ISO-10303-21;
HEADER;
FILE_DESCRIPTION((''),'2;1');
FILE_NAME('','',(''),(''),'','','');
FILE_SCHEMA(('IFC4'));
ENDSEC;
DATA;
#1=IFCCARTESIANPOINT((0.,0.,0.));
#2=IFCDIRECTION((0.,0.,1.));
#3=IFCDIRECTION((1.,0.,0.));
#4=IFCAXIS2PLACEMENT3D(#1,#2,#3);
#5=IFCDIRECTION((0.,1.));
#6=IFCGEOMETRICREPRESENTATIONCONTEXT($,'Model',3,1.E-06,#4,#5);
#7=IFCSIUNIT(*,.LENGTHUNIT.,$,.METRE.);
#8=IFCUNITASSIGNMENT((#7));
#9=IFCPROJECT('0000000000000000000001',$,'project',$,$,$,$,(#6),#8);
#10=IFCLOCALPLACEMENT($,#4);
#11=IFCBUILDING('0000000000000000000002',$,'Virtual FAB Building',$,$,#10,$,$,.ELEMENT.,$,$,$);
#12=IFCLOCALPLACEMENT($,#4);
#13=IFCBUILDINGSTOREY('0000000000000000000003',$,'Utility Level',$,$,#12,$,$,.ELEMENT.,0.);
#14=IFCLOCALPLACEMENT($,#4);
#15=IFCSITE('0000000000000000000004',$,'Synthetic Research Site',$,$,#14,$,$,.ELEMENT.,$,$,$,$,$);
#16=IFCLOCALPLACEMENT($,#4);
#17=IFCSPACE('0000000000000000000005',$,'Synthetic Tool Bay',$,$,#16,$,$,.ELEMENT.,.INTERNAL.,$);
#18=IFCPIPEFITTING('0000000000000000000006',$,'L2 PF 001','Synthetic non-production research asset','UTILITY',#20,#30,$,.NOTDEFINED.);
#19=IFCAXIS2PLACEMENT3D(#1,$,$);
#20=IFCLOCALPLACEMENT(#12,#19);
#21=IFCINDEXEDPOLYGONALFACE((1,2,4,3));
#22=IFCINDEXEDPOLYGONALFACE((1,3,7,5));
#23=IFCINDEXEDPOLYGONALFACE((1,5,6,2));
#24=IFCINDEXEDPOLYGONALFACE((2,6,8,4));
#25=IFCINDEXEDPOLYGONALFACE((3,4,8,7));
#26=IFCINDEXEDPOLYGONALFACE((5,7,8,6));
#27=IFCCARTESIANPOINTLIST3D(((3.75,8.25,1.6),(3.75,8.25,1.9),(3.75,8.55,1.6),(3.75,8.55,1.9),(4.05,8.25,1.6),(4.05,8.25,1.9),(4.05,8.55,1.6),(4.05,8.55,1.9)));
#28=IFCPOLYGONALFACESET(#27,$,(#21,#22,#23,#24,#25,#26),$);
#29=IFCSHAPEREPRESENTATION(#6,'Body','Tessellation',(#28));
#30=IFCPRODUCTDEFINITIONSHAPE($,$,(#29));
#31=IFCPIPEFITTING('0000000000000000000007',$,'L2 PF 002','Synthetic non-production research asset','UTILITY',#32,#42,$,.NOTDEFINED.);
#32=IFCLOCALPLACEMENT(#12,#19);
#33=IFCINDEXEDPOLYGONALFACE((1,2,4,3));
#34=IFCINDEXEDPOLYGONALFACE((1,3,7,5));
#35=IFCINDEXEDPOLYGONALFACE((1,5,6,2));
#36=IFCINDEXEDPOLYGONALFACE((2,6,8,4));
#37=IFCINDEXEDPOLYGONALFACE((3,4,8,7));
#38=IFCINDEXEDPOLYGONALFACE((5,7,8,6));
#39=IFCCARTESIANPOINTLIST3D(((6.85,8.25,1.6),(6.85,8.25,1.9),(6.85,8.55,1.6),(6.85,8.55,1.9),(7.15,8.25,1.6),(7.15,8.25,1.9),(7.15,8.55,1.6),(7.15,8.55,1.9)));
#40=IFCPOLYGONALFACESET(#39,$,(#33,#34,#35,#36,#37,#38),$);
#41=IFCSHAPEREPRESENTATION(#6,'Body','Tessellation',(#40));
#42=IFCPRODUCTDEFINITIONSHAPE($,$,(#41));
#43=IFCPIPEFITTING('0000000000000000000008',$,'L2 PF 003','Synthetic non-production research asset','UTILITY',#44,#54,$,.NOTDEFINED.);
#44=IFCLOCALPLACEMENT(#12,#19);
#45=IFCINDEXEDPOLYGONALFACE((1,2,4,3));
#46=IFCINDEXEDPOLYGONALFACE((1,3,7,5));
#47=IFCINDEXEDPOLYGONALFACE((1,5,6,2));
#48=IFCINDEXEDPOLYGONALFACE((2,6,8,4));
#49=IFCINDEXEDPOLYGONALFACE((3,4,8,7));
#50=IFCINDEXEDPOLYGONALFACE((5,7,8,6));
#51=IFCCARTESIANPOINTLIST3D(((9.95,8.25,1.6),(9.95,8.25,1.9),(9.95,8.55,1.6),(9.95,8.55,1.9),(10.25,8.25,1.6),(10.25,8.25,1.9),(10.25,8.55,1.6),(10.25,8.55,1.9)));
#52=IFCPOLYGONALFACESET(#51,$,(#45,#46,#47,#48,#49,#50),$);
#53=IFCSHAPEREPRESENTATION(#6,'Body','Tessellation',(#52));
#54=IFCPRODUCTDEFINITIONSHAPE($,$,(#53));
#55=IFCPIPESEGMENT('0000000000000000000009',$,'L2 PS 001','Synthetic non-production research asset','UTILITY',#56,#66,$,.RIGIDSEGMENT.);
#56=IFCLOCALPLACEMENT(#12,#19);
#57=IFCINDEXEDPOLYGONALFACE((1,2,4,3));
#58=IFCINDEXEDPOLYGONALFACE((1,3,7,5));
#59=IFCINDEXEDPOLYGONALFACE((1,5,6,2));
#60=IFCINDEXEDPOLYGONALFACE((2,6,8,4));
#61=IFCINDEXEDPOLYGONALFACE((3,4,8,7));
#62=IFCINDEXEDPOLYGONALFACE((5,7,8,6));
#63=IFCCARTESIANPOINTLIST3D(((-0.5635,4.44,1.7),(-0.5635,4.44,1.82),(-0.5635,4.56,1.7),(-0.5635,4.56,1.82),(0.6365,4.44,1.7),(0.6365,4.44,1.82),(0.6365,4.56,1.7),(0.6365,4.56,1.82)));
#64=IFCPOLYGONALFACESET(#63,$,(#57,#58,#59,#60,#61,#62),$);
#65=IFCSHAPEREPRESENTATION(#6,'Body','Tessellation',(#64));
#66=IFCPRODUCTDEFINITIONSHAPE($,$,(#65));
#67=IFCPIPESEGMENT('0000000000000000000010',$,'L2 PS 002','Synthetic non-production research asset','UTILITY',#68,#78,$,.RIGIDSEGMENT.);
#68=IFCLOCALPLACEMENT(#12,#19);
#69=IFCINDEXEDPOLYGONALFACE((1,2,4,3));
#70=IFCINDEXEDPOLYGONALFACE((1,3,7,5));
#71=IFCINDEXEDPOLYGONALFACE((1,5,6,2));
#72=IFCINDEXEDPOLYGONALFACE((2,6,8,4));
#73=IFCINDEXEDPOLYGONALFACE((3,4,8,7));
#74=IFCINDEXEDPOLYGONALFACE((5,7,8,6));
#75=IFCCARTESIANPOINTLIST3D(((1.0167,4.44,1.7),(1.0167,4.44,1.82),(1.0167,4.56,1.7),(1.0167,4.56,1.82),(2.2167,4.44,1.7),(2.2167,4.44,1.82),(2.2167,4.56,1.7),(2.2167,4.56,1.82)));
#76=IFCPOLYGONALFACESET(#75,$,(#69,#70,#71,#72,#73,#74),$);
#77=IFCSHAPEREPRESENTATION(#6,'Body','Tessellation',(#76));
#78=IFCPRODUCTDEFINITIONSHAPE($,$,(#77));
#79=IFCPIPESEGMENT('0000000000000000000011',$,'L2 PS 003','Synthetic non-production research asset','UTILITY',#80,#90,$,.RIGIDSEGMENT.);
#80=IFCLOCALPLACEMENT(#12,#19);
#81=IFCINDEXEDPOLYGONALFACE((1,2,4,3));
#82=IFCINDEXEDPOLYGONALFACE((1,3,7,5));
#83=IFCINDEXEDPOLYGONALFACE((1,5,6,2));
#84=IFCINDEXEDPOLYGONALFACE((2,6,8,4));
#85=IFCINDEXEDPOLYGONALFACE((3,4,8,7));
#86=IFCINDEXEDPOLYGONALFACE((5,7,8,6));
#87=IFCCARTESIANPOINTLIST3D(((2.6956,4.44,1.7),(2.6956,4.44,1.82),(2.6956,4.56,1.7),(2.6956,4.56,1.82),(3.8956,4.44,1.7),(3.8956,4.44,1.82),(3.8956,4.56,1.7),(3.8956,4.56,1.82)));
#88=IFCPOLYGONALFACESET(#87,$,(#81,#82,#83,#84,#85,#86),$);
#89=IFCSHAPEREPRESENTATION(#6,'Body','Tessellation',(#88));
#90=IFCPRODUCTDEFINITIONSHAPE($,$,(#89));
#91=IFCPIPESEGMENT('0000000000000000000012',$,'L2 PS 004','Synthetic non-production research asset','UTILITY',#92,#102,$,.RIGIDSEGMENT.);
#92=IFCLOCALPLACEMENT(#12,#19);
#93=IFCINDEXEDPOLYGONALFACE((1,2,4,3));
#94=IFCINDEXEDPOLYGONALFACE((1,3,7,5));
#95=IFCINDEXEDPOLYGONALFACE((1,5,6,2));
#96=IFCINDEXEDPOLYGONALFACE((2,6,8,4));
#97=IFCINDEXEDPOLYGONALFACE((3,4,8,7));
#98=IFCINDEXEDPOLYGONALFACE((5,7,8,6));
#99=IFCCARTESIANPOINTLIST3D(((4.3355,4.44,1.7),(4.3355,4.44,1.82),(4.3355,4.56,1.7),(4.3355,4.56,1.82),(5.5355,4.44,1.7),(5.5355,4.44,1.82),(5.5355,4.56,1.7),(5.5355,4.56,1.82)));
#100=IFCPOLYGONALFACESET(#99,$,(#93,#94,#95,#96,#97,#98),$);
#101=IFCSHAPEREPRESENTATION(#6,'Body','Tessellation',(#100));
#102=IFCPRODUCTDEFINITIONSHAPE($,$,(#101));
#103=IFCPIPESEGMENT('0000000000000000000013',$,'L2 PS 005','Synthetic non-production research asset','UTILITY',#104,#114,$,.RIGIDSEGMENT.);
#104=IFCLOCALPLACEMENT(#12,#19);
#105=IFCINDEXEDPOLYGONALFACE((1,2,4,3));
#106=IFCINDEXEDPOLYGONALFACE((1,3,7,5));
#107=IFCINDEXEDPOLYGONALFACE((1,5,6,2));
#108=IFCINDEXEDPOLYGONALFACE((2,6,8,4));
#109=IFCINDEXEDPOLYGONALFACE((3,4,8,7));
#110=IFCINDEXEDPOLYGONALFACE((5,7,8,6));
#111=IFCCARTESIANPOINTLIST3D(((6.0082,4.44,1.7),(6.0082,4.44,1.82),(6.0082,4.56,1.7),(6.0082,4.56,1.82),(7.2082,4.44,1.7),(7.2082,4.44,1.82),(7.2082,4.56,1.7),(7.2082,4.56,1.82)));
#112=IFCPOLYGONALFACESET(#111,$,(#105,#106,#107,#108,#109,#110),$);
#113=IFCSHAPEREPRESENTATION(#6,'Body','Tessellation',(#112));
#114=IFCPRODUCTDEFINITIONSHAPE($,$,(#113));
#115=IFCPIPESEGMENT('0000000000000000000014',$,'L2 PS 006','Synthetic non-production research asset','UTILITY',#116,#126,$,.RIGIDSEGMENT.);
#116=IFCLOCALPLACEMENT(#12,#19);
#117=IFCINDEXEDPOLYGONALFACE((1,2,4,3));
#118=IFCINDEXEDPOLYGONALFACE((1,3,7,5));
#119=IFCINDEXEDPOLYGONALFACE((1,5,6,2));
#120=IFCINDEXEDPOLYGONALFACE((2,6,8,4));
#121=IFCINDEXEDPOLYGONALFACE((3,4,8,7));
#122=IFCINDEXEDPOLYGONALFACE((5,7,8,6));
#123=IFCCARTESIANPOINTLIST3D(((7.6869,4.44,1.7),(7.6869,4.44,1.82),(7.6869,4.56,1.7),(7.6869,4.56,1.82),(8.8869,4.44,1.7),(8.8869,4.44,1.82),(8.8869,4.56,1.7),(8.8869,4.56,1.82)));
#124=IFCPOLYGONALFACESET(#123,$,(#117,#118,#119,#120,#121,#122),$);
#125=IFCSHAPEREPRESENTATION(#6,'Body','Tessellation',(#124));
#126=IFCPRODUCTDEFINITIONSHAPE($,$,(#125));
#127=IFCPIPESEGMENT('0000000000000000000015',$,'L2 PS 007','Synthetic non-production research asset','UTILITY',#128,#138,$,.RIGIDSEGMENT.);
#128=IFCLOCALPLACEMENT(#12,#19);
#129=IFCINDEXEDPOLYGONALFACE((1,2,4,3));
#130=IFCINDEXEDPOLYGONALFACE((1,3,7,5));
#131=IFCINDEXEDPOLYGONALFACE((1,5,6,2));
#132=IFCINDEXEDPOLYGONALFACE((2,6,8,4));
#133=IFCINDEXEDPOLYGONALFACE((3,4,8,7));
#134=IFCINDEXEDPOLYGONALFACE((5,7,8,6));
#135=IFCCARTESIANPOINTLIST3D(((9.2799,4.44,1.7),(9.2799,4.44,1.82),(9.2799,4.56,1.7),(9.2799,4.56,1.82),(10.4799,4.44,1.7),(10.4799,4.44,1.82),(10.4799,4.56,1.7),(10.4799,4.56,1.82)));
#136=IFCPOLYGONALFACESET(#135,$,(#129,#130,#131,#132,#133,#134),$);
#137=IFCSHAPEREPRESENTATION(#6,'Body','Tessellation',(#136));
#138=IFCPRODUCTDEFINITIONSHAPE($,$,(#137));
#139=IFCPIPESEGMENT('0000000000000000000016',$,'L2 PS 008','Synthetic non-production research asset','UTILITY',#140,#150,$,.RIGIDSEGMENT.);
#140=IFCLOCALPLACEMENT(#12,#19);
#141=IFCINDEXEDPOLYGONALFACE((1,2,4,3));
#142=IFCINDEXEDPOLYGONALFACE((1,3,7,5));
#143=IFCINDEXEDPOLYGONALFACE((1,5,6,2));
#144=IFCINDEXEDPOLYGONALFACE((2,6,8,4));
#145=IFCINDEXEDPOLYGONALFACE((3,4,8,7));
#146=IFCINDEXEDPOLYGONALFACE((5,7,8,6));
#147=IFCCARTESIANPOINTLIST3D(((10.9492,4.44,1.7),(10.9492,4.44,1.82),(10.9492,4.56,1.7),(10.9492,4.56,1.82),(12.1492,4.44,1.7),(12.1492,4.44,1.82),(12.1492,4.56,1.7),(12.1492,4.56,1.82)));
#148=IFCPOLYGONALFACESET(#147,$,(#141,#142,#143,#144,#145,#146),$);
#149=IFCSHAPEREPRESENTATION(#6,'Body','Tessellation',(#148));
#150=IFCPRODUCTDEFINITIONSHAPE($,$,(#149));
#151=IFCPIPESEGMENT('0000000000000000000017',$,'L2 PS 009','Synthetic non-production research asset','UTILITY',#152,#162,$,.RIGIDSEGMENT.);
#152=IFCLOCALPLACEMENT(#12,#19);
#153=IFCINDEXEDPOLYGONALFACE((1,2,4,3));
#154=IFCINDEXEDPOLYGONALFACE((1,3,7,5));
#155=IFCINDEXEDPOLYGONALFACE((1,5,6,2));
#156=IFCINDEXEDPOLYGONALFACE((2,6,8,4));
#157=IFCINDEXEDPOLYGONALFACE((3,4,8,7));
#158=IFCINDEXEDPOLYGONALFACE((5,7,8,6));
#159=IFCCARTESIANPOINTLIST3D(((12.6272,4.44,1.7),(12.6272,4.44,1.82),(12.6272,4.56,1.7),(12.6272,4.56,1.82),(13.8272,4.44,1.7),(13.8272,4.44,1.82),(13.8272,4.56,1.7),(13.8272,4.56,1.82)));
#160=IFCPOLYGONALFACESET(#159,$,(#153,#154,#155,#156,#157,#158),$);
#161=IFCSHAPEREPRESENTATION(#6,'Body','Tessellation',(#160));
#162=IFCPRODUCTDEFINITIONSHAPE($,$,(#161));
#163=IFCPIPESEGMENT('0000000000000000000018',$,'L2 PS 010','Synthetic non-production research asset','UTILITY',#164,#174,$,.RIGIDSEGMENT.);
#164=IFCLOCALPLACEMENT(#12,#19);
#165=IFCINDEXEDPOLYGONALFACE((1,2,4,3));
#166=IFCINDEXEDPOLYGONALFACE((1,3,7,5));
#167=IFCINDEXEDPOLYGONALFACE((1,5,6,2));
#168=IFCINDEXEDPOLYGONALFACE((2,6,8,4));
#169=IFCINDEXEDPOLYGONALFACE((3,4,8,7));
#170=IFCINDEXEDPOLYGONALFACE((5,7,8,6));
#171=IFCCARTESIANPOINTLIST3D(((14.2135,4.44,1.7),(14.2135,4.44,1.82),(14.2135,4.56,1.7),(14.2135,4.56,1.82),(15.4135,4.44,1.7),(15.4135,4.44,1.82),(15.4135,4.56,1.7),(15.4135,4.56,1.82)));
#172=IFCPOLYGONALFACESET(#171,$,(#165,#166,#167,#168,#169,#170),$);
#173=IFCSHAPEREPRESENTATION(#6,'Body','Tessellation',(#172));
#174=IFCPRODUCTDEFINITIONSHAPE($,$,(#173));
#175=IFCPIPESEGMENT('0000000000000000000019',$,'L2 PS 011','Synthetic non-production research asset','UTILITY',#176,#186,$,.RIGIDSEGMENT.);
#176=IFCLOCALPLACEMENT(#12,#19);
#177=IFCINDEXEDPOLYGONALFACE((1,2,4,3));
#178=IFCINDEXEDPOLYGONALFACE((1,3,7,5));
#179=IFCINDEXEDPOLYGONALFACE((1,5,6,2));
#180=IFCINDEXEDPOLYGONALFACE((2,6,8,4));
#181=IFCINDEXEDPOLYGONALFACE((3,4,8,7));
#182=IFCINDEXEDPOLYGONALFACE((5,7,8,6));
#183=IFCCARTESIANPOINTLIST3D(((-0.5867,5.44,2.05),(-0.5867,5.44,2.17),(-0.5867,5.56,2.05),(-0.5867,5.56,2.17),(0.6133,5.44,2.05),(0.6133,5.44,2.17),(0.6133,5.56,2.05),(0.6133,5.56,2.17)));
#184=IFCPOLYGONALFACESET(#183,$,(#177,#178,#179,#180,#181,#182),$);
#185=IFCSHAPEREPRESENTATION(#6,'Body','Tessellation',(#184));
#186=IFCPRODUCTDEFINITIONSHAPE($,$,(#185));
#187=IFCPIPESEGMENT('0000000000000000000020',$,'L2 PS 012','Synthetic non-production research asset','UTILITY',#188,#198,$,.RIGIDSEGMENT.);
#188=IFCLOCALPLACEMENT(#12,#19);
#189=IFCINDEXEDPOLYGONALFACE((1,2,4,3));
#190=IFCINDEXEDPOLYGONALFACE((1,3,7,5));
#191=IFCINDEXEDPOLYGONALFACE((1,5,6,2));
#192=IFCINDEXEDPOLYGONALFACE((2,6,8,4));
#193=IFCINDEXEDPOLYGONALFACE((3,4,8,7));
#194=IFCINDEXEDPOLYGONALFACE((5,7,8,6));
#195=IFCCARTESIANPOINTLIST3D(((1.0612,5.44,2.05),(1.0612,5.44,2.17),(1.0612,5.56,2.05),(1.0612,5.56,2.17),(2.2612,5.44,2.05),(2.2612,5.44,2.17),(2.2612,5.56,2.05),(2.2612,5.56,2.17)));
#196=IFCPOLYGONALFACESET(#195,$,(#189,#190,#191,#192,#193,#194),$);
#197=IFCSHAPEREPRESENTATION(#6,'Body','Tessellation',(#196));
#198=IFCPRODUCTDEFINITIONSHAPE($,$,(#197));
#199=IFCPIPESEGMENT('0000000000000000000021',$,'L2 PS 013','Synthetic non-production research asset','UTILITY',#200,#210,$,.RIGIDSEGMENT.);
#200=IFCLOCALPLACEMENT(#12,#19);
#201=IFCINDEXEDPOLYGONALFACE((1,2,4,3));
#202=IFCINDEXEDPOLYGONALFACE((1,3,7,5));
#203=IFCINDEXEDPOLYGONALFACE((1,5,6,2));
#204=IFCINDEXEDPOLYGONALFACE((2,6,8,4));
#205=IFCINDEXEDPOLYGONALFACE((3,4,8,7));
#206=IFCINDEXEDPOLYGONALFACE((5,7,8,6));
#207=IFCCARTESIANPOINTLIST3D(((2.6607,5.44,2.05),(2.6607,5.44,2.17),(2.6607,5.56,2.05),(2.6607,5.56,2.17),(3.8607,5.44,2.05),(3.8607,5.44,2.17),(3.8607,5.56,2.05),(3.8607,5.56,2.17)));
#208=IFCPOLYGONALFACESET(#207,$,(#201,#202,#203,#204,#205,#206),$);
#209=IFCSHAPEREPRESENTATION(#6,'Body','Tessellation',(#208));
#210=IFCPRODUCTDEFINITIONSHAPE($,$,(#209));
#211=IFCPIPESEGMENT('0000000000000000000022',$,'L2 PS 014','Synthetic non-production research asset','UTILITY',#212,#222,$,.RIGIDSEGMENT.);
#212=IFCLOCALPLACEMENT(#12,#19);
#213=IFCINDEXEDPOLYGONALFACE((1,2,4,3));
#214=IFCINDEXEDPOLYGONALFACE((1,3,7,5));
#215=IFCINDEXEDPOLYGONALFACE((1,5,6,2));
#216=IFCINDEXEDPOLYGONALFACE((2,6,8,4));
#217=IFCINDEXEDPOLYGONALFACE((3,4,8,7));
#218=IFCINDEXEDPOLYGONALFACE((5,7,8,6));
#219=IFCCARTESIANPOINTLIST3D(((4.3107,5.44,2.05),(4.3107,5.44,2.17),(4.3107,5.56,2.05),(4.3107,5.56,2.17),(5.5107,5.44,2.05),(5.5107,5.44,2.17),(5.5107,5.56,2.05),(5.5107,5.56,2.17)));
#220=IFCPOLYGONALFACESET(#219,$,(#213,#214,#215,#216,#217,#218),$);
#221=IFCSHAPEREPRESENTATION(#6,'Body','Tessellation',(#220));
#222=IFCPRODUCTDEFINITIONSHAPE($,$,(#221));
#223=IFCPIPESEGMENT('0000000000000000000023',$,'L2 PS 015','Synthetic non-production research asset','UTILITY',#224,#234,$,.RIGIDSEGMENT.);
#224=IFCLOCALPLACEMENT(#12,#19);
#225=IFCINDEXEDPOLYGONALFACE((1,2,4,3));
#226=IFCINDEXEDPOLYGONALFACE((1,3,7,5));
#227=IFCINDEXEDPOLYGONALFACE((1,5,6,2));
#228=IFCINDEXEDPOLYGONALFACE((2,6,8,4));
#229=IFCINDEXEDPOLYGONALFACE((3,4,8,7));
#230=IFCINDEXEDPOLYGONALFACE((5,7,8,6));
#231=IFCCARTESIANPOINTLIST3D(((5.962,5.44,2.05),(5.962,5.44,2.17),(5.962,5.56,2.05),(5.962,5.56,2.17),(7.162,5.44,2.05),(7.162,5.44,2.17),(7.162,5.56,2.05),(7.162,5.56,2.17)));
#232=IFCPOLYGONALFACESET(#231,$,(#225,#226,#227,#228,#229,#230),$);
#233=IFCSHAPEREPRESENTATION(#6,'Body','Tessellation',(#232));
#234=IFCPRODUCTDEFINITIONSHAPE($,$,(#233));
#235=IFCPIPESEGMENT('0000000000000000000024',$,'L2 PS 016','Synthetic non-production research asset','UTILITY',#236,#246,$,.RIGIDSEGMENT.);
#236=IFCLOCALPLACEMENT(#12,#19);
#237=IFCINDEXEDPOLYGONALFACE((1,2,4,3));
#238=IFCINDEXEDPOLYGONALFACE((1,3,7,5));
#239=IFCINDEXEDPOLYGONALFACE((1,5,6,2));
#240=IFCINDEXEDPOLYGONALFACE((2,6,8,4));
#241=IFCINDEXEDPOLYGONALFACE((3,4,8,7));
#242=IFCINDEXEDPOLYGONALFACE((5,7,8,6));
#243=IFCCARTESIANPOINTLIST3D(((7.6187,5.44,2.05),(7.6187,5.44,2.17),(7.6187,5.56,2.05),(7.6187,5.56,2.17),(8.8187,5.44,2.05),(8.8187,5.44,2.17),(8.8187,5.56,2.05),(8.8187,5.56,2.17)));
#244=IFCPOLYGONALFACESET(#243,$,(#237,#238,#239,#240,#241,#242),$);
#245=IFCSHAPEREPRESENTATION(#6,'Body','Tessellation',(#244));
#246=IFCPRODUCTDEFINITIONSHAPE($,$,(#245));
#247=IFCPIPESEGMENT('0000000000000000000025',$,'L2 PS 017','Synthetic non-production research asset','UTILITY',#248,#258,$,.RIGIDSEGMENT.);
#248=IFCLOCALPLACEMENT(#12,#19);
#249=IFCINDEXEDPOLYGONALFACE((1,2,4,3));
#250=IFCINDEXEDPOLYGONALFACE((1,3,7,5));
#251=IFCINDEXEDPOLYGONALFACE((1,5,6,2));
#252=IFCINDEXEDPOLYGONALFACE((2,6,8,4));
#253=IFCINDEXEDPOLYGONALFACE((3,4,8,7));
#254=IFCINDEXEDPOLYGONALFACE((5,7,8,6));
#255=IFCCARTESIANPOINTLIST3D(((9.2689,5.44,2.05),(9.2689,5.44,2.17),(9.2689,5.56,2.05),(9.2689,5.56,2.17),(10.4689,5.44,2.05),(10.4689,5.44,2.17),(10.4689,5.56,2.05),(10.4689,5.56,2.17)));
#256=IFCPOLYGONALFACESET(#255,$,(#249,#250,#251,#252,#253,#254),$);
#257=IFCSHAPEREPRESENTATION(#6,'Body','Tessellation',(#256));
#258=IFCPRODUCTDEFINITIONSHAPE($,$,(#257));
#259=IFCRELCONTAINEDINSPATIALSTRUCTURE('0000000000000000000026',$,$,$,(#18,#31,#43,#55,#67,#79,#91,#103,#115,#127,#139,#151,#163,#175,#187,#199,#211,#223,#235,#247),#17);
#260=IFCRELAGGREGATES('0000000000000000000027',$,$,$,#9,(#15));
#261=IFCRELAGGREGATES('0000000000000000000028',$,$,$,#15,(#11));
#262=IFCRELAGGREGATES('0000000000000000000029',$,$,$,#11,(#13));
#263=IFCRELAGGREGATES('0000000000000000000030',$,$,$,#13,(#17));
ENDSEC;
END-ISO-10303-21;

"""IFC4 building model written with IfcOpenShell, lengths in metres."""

from ifc_helpers import new_model, si_unit, direction, frame, origin_with_axes, origin_2d_with_axis, place, context, project, spatial, rectangle, extrude, element, save


model = new_model("IFC4")

# Units and contexts
model_context = context("Model", 3, precision=1e-06, world=origin_with_axes(), true_north=direction((0.0, 1.0)))
ifc_project = project(units=[si_unit("LENGTHUNIT", "METRE")], contexts=[model_context])

# Site, building, storey, space
site_placement = place(None, origin_with_axes())
site = spatial("IfcSite", under=ifc_project, at=site_placement, Name="Synthetic Research Site", CompositionType="ELEMENT")
building_placement = place(None, origin_with_axes())
building = spatial("IfcBuilding", under=site, at=building_placement, Name="Virtual FAB Building", CompositionType="ELEMENT")
storey_placement = place(None, origin_with_axes())
storey = spatial("IfcBuildingStorey", under=building, at=storey_placement, Name="Utility Level", CompositionType="ELEMENT", Elevation=0.0)
space_placement = place(None, origin_with_axes())
space = spatial("IfcSpace", under=storey, at=space_placement, Name="Synthetic Tool Bay", CompositionType="ELEMENT", PredefinedType="INTERNAL")

# Pipe fittings
for number, where, z_axis, x_axis, name in (
    (1, (3.9, 8.4, 1.6), (0.0, 0.0, 1.0), (1.0, 0.0, 0.0), "L2 PF 001"),
    (2, (7.0, 8.4, 1.6), (0.0, 0.0, 1.0), (1.0, 0.0, 0.0), "L2 PF 002"),
    (3, (10.1, 8.4, 1.6), (0.0, 0.0, 1.0), (1.0, 0.0, 0.0), "L2 PF 003"),
):
    element("IfcPipeFitting", number, at=place(None, frame(where, z_axis=z_axis, x_axis=x_axis)), inside=space, Name=name, Description="Synthetic non-production research asset", ObjectType="UTILITY", PredefinedType="NOTDEFINED", context=model_context, shape_type="SweptSolid", body=[
        extrude(rectangle(XDim=0.3, YDim=0.3, at=origin_2d_with_axis()), origin_with_axes(), (0.0, 0.0, 1.0), 0.3),
    ])

# Pipe segments
for number, where, z_axis, x_axis, name in (
    (4, (0.0365, 4.5, 1.7), (0.0, 0.0, 1.0), (1.0, 0.0, 0.0), "L2 PS 001"),
    (5, (1.6167, 4.5, 1.7), (0.0, 0.0, 1.0), (1.0, 0.0, 0.0), "L2 PS 002"),
    (6, (3.2956, 4.5, 1.7), (0.0, 0.0, 1.0), (1.0, 0.0, 0.0), "L2 PS 003"),
    (7, (4.9355, 4.5, 1.7), (0.0, 0.0, 1.0), (1.0, 0.0, 0.0), "L2 PS 004"),
    (8, (6.6082, 4.5, 1.7), (0.0, 0.0, 1.0), (1.0, 0.0, 0.0), "L2 PS 005"),
    (9, (8.2869, 4.5, 1.7), (0.0, 0.0, 1.0), (1.0, 0.0, 0.0), "L2 PS 006"),
    (10, (9.8799, 4.5, 1.7), (0.0, 0.0, 1.0), (1.0, 0.0, 0.0), "L2 PS 007"),
    (11, (11.5492, 4.5, 1.7), (0.0, 0.0, 1.0), (1.0, 0.0, 0.0), "L2 PS 008"),
    (12, (13.2272, 4.5, 1.7), (0.0, 0.0, 1.0), (1.0, 0.0, 0.0), "L2 PS 009"),
    (13, (14.8135, 4.5, 1.7), (0.0, 0.0, 1.0), (1.0, 0.0, 0.0), "L2 PS 010"),
    (14, (0.0133, 5.5, 2.05), (0.0, 0.0, 1.0), (1.0, 0.0, 0.0), "L2 PS 011"),
    (15, (1.6612, 5.5, 2.05), (0.0, 0.0, 1.0), (1.0, 0.0, 0.0), "L2 PS 012"),
    (16, (3.2607, 5.5, 2.05), (0.0, 0.0, 1.0), (1.0, 0.0, 0.0), "L2 PS 013"),
    (17, (4.9107, 5.5, 2.05), (0.0, 0.0, 1.0), (1.0, 0.0, 0.0), "L2 PS 014"),
    (18, (6.562, 5.5, 2.05), (0.0, 0.0, 1.0), (1.0, 0.0, 0.0), "L2 PS 015"),
    (19, (8.2187, 5.5, 2.05), (0.0, 0.0, 1.0), (1.0, 0.0, 0.0), "L2 PS 016"),
    (20, (9.8689, 5.5, 2.05), (0.0, 0.0, 1.0), (1.0, 0.0, 0.0), "L2 PS 017"),
):
    element("IfcPipeSegment", number, at=place(None, frame(where, z_axis=z_axis, x_axis=x_axis)), inside=space, Name=name, Description="Synthetic non-production research asset", ObjectType="UTILITY", PredefinedType="RIGIDSEGMENT", context=model_context, shape_type="SweptSolid", body=[
        extrude(rectangle(XDim=1.2, YDim=0.12, at=origin_2d_with_axis()), origin_with_axes(), (0.0, 0.0, 1.0), 0.12),
    ])

save(model, "model.ifc")
